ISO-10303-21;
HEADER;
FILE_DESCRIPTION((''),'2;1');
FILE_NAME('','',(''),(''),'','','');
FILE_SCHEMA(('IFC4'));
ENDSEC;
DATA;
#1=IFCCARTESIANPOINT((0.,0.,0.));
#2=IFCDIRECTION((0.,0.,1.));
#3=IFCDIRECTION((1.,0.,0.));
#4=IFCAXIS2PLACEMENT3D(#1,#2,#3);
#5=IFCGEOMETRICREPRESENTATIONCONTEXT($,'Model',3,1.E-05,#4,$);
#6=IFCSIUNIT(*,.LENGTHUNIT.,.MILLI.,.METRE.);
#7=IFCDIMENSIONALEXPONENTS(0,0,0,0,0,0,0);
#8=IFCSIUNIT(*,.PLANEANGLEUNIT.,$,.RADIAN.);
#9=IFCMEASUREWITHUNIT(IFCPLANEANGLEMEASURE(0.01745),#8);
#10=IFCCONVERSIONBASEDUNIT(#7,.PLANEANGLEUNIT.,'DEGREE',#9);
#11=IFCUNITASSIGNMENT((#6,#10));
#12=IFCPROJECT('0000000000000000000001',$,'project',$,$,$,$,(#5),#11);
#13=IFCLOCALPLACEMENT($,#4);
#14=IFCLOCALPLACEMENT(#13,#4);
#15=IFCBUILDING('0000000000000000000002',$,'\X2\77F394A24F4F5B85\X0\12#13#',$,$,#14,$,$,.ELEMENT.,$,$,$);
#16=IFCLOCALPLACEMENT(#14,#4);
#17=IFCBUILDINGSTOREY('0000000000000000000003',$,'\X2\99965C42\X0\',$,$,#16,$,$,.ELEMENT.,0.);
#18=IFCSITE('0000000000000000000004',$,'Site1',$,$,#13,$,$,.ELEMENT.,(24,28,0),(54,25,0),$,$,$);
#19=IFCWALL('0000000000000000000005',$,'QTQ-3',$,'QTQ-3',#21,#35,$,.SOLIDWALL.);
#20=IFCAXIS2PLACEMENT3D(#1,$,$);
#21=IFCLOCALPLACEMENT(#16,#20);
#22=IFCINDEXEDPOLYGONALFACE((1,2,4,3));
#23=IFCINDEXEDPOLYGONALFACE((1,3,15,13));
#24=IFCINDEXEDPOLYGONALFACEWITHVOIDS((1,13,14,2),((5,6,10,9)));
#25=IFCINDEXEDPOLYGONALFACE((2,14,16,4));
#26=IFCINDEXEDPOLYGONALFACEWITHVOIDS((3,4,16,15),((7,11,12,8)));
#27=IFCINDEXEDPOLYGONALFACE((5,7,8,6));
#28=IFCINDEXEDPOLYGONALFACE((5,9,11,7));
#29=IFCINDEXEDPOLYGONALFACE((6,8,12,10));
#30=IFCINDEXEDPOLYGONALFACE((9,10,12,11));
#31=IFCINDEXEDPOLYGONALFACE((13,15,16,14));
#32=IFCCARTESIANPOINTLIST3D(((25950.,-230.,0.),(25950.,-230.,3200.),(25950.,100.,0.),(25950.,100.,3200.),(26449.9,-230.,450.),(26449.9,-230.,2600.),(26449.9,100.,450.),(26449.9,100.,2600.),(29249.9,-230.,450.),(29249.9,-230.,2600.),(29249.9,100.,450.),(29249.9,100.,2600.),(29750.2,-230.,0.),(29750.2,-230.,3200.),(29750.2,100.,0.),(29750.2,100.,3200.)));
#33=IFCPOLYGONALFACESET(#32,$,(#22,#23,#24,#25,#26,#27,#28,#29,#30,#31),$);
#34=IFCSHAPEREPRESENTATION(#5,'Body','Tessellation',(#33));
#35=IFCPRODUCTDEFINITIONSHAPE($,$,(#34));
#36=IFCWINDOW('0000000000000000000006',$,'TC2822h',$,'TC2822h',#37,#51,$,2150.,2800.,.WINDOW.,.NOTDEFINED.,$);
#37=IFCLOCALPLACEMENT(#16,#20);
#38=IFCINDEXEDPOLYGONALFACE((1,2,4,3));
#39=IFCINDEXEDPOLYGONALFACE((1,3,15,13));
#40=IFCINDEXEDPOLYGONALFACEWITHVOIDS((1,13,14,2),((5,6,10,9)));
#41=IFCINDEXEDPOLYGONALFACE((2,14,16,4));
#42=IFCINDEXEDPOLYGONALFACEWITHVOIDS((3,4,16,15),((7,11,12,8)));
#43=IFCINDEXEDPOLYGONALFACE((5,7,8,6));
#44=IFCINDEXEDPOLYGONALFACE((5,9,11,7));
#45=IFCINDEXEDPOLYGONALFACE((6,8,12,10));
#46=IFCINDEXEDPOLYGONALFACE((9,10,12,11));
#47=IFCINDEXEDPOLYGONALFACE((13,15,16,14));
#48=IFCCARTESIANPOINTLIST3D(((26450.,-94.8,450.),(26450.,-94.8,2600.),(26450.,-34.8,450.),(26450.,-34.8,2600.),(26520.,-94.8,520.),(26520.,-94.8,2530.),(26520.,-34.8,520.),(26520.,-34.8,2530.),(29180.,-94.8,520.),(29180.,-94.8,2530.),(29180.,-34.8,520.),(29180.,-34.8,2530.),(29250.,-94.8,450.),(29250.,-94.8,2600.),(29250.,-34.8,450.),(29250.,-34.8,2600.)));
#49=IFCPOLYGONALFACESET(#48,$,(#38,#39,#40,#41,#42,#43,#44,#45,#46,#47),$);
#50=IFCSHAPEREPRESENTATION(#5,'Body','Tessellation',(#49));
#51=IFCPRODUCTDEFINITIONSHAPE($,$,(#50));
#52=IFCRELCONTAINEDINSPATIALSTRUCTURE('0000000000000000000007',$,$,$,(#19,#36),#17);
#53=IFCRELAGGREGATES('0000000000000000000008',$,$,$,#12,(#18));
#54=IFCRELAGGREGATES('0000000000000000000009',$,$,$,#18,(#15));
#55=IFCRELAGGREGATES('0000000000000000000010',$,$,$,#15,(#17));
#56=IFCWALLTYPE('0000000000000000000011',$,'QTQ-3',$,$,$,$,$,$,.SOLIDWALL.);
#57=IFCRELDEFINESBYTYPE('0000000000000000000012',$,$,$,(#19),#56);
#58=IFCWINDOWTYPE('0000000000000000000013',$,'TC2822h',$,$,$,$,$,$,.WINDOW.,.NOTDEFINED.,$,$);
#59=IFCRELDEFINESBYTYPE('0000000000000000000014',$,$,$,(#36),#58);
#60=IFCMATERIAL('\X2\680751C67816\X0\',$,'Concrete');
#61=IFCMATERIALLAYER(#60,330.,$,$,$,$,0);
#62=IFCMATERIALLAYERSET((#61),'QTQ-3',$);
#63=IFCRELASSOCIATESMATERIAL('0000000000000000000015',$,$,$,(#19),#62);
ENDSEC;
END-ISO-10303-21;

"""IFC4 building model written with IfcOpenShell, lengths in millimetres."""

from ifc_helpers import new_model, entity, si_unit, converted_unit, frame, origin_with_axes, place, context, project, spatial, polyline, outline, extrude, material, layer, layer_set, type_object, element, fill, save


model = new_model("IFC4")

# Units and contexts
model_context = context("Model", 3, precision=1e-05, world=origin_with_axes())
ifc_project = project(units=[si_unit("LENGTHUNIT", "METRE", prefix="MILLI"), converted_unit("PLANEANGLEUNIT", "DEGREE", entity("IfcPlaneAngleMeasure", 0.01745), si_unit("PLANEANGLEUNIT", "RADIAN"), dimensions=[0, 0, 0, 0, 0, 0, 0])], contexts=[model_context])

# Site, building, storey
site_placement = place(None, origin_with_axes())
site = spatial("IfcSite", under=ifc_project, at=site_placement, Name="Site1", CompositionType="ELEMENT", RefLatitude=(24, 28, 0), RefLongitude=(54, 25, 0))
building_placement = place(site_placement, origin_with_axes())
building = spatial("IfcBuilding", under=site, at=building_placement, Name="石钢住宅12#13#", CompositionType="ELEMENT")
storey_placement = place(building_placement, origin_with_axes())
storey = spatial("IfcBuildingStorey", under=building, at=storey_placement, Name="首层", CompositionType="ELEMENT", Elevation=0.0)

# Shared definitions
ifc_material = material(Name="标准砖", Category="Concrete")
ifc_layer = layer(ifc_material, 330.0, Priority=0)
ifc_layer_set = layer_set([ifc_layer], Name="QTQ-3")
wall_type = type_object("IfcWallType", Name="QTQ-3", PredefinedType="SOLIDWALL")

# Wall, opening, window
wall_1_placement = place(storey_placement, origin_with_axes())
wall_1 = element("IfcWall", 1, at=wall_1_placement, inside=storey, type_object=wall_type, material=ifc_layer_set, Name="QTQ-3", ObjectType="QTQ-3", PredefinedType="SOLIDWALL", context=model_context, shape_type="SweptSolid", body=[
    extrude(outline(polyline([(0.0, 0.0), (3200.0, 0.0), (3200.0, 3800.2), (0.0, 3800.2), (0.0, 0.0)])), frame((25950.0, 100.0, 3200.0), z_axis=(0.0, -1.0, 0.0), x_axis=(0.0, 0.0, -1.0)), (0.0, 0.0, 1.0), 330.0),
])
opening_1_placement = place(storey_placement, origin_with_axes())
opening_1 = element("IfcOpeningElement", 2, at=opening_1_placement, cuts=wall_1, PredefinedType="OPENING", context=model_context, shape_type="SweptSolid", body=[
    extrude(outline(polyline([(0.0, 0.0), (2800.0, 0.0), (2800.0, 2150.0), (0.0, 2150.0), (0.0, 0.0)])), frame((26449.9, 1100.0, 450.0), z_axis=(0.0, -1.0, 0.0), x_axis=(1.0, 0.0, 0.0)), (0.0, 0.0, 1.0), 2330.0),
])
window_type_1 = type_object("IfcWindowType", Name="TC2822h", PartitioningType="NOTDEFINED", PredefinedType="WINDOW")
window_1_placement = place(storey_placement, origin_with_axes())
window_1 = element("IfcWindow", 3, at=window_1_placement, inside=storey, type_object=window_type_1, Name="TC2822h", ObjectType="TC2822h", OverallHeight=2150.0, OverallWidth=2800.0, PartitioningType="NOTDEFINED", PredefinedType="WINDOW", context=model_context, shape_type="SweptSolid", body=[
    extrude(outline(polyline([(-1400.0, -1075.0), (1400.0, -1075.0), (1400.0, 1075.0), (-1400.0, 1075.0), (-1400.0, -1075.0)]), holes=[polyline([(-1330.0, -1005.0), (-1330.0, 1005.0), (1330.0, 1005.0), (1330.0, -1005.0), (-1330.0, -1005.0)])]), frame((27850.0, -34.8, 1525.0), z_axis=(0.0, -1.0, 0.0), x_axis=(1.0, 0.0, 0.0)), (0.0, 0.0, 1.0), 60.0),
])
fill(opening_1, window_1)

save(model, "model.ifc")
